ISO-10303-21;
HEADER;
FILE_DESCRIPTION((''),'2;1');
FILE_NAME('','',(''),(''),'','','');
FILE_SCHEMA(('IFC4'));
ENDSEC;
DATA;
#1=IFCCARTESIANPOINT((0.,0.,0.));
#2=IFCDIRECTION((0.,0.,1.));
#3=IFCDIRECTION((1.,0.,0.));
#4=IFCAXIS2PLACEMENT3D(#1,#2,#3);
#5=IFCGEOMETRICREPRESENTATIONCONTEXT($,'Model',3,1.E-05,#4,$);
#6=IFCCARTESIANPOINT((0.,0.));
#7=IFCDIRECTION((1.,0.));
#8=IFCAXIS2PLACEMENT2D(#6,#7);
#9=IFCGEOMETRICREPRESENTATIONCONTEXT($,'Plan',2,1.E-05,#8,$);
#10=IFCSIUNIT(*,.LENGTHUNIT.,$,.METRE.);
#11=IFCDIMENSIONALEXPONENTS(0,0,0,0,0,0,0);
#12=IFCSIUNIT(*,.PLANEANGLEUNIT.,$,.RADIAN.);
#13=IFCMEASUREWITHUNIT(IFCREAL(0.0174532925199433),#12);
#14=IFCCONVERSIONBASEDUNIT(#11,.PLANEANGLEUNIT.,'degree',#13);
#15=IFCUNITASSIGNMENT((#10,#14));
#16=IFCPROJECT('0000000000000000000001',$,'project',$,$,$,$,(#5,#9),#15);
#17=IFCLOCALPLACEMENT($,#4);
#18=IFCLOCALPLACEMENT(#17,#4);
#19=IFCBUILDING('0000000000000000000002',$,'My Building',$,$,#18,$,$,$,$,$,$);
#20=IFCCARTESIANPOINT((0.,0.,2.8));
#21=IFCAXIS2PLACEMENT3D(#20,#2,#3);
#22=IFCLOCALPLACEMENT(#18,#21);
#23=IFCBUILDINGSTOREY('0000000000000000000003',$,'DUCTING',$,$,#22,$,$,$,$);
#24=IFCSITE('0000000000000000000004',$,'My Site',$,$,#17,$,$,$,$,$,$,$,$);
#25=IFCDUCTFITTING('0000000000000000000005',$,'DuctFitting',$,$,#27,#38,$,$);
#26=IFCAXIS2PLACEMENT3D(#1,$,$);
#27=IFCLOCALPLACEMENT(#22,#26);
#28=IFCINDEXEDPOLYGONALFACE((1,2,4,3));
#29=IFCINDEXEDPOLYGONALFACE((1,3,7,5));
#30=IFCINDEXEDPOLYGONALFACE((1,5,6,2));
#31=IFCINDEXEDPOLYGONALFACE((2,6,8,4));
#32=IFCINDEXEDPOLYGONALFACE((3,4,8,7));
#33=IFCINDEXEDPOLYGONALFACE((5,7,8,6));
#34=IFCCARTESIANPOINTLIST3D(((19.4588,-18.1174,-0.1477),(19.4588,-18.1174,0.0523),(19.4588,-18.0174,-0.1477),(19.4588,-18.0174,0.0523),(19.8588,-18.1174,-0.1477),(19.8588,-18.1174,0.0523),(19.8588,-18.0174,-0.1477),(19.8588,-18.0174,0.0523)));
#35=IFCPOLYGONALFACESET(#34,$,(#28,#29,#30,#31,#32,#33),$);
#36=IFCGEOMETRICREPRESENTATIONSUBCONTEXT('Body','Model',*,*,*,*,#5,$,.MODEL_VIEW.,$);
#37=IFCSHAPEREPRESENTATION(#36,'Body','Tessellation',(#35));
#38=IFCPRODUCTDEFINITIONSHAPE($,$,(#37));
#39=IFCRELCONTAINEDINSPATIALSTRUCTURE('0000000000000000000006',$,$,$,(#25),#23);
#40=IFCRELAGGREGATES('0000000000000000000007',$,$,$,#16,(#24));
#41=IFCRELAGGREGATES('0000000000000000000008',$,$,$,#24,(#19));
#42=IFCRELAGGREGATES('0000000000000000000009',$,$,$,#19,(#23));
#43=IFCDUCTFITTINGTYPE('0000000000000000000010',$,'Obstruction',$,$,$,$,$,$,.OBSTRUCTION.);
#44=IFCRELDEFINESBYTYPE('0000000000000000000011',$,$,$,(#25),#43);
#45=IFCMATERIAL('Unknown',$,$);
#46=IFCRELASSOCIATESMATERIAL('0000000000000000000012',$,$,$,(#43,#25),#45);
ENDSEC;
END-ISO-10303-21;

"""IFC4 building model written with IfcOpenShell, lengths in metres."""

from ifc_helpers import new_model, entity, si_unit, converted_unit, frame, origin_with_axes, origin_2d_with_axis, place, context, subcontext, project, spatial, rectangle, extrude, material, material_profile, profile_set, profile_usage, type_object, element, save


model = new_model("IFC4")

# Units and contexts
model_context = context("Model", 3, precision=1e-05, world=origin_with_axes())
plan_context = context("Plan", 2, precision=1e-05, world=origin_2d_with_axis())
body_context = subcontext(model_context, "Body", "Model", "MODEL_VIEW")
ifc_project = project(units=[si_unit("LENGTHUNIT", "METRE"), converted_unit("PLANEANGLEUNIT", "degree", entity("IfcReal", 0.0174532925199433), si_unit("PLANEANGLEUNIT", "RADIAN"), dimensions=[0, 0, 0, 0, 0, 0, 0])], contexts=[model_context, plan_context])

# Site, building, storey
site_placement = place(None, origin_with_axes())
site = spatial("IfcSite", under=ifc_project, at=site_placement, Name="My Site")
building_placement = place(site_placement, origin_with_axes())
building = spatial("IfcBuilding", under=site, at=building_placement, Name="My Building")
storey_placement = place(building_placement, frame((0.0, 0.0, 2.8), z_axis=(0.0, 0.0, 1.0), x_axis=(1.0, 0.0, 0.0)))
storey = spatial("IfcBuildingStorey", under=building, at=storey_placement, Name="DUCTING")

# Shared definitions
ifc_material = material(Name="Unknown")

# Duct fitting
ifc_material_profile_1 = material_profile(ifc_material, rectangle(XDim=0.4, YDim=0.2))
ifc_profile_set_1 = profile_set([ifc_material_profile_1])
duct_fitting_type_1 = type_object("IfcDuctFittingType", Name="Obstruction", PredefinedType="OBSTRUCTION", material=ifc_profile_set_1)
ifc_profile_usage_1 = profile_usage(ifc_profile_set_1, cardinal=5)
duct_fitting_1_placement = place(storey_placement, frame((19.6588, -18.1174, -0.0477), z_axis=(0.0, 1.0, 0.0), x_axis=(-1.0, 0.0, 0.0)))
element("IfcDuctFitting", 1, at=duct_fitting_1_placement, inside=storey, type_object=duct_fitting_type_1, material=ifc_profile_usage_1, Name="DuctFitting", context=body_context, shape_type="SweptSolid", body=[
    extrude(rectangle(XDim=0.4, YDim=0.2), origin_with_axes(), (0.0, 0.0, 1.0), 0.1),
])

save(model, "model.ifc")
